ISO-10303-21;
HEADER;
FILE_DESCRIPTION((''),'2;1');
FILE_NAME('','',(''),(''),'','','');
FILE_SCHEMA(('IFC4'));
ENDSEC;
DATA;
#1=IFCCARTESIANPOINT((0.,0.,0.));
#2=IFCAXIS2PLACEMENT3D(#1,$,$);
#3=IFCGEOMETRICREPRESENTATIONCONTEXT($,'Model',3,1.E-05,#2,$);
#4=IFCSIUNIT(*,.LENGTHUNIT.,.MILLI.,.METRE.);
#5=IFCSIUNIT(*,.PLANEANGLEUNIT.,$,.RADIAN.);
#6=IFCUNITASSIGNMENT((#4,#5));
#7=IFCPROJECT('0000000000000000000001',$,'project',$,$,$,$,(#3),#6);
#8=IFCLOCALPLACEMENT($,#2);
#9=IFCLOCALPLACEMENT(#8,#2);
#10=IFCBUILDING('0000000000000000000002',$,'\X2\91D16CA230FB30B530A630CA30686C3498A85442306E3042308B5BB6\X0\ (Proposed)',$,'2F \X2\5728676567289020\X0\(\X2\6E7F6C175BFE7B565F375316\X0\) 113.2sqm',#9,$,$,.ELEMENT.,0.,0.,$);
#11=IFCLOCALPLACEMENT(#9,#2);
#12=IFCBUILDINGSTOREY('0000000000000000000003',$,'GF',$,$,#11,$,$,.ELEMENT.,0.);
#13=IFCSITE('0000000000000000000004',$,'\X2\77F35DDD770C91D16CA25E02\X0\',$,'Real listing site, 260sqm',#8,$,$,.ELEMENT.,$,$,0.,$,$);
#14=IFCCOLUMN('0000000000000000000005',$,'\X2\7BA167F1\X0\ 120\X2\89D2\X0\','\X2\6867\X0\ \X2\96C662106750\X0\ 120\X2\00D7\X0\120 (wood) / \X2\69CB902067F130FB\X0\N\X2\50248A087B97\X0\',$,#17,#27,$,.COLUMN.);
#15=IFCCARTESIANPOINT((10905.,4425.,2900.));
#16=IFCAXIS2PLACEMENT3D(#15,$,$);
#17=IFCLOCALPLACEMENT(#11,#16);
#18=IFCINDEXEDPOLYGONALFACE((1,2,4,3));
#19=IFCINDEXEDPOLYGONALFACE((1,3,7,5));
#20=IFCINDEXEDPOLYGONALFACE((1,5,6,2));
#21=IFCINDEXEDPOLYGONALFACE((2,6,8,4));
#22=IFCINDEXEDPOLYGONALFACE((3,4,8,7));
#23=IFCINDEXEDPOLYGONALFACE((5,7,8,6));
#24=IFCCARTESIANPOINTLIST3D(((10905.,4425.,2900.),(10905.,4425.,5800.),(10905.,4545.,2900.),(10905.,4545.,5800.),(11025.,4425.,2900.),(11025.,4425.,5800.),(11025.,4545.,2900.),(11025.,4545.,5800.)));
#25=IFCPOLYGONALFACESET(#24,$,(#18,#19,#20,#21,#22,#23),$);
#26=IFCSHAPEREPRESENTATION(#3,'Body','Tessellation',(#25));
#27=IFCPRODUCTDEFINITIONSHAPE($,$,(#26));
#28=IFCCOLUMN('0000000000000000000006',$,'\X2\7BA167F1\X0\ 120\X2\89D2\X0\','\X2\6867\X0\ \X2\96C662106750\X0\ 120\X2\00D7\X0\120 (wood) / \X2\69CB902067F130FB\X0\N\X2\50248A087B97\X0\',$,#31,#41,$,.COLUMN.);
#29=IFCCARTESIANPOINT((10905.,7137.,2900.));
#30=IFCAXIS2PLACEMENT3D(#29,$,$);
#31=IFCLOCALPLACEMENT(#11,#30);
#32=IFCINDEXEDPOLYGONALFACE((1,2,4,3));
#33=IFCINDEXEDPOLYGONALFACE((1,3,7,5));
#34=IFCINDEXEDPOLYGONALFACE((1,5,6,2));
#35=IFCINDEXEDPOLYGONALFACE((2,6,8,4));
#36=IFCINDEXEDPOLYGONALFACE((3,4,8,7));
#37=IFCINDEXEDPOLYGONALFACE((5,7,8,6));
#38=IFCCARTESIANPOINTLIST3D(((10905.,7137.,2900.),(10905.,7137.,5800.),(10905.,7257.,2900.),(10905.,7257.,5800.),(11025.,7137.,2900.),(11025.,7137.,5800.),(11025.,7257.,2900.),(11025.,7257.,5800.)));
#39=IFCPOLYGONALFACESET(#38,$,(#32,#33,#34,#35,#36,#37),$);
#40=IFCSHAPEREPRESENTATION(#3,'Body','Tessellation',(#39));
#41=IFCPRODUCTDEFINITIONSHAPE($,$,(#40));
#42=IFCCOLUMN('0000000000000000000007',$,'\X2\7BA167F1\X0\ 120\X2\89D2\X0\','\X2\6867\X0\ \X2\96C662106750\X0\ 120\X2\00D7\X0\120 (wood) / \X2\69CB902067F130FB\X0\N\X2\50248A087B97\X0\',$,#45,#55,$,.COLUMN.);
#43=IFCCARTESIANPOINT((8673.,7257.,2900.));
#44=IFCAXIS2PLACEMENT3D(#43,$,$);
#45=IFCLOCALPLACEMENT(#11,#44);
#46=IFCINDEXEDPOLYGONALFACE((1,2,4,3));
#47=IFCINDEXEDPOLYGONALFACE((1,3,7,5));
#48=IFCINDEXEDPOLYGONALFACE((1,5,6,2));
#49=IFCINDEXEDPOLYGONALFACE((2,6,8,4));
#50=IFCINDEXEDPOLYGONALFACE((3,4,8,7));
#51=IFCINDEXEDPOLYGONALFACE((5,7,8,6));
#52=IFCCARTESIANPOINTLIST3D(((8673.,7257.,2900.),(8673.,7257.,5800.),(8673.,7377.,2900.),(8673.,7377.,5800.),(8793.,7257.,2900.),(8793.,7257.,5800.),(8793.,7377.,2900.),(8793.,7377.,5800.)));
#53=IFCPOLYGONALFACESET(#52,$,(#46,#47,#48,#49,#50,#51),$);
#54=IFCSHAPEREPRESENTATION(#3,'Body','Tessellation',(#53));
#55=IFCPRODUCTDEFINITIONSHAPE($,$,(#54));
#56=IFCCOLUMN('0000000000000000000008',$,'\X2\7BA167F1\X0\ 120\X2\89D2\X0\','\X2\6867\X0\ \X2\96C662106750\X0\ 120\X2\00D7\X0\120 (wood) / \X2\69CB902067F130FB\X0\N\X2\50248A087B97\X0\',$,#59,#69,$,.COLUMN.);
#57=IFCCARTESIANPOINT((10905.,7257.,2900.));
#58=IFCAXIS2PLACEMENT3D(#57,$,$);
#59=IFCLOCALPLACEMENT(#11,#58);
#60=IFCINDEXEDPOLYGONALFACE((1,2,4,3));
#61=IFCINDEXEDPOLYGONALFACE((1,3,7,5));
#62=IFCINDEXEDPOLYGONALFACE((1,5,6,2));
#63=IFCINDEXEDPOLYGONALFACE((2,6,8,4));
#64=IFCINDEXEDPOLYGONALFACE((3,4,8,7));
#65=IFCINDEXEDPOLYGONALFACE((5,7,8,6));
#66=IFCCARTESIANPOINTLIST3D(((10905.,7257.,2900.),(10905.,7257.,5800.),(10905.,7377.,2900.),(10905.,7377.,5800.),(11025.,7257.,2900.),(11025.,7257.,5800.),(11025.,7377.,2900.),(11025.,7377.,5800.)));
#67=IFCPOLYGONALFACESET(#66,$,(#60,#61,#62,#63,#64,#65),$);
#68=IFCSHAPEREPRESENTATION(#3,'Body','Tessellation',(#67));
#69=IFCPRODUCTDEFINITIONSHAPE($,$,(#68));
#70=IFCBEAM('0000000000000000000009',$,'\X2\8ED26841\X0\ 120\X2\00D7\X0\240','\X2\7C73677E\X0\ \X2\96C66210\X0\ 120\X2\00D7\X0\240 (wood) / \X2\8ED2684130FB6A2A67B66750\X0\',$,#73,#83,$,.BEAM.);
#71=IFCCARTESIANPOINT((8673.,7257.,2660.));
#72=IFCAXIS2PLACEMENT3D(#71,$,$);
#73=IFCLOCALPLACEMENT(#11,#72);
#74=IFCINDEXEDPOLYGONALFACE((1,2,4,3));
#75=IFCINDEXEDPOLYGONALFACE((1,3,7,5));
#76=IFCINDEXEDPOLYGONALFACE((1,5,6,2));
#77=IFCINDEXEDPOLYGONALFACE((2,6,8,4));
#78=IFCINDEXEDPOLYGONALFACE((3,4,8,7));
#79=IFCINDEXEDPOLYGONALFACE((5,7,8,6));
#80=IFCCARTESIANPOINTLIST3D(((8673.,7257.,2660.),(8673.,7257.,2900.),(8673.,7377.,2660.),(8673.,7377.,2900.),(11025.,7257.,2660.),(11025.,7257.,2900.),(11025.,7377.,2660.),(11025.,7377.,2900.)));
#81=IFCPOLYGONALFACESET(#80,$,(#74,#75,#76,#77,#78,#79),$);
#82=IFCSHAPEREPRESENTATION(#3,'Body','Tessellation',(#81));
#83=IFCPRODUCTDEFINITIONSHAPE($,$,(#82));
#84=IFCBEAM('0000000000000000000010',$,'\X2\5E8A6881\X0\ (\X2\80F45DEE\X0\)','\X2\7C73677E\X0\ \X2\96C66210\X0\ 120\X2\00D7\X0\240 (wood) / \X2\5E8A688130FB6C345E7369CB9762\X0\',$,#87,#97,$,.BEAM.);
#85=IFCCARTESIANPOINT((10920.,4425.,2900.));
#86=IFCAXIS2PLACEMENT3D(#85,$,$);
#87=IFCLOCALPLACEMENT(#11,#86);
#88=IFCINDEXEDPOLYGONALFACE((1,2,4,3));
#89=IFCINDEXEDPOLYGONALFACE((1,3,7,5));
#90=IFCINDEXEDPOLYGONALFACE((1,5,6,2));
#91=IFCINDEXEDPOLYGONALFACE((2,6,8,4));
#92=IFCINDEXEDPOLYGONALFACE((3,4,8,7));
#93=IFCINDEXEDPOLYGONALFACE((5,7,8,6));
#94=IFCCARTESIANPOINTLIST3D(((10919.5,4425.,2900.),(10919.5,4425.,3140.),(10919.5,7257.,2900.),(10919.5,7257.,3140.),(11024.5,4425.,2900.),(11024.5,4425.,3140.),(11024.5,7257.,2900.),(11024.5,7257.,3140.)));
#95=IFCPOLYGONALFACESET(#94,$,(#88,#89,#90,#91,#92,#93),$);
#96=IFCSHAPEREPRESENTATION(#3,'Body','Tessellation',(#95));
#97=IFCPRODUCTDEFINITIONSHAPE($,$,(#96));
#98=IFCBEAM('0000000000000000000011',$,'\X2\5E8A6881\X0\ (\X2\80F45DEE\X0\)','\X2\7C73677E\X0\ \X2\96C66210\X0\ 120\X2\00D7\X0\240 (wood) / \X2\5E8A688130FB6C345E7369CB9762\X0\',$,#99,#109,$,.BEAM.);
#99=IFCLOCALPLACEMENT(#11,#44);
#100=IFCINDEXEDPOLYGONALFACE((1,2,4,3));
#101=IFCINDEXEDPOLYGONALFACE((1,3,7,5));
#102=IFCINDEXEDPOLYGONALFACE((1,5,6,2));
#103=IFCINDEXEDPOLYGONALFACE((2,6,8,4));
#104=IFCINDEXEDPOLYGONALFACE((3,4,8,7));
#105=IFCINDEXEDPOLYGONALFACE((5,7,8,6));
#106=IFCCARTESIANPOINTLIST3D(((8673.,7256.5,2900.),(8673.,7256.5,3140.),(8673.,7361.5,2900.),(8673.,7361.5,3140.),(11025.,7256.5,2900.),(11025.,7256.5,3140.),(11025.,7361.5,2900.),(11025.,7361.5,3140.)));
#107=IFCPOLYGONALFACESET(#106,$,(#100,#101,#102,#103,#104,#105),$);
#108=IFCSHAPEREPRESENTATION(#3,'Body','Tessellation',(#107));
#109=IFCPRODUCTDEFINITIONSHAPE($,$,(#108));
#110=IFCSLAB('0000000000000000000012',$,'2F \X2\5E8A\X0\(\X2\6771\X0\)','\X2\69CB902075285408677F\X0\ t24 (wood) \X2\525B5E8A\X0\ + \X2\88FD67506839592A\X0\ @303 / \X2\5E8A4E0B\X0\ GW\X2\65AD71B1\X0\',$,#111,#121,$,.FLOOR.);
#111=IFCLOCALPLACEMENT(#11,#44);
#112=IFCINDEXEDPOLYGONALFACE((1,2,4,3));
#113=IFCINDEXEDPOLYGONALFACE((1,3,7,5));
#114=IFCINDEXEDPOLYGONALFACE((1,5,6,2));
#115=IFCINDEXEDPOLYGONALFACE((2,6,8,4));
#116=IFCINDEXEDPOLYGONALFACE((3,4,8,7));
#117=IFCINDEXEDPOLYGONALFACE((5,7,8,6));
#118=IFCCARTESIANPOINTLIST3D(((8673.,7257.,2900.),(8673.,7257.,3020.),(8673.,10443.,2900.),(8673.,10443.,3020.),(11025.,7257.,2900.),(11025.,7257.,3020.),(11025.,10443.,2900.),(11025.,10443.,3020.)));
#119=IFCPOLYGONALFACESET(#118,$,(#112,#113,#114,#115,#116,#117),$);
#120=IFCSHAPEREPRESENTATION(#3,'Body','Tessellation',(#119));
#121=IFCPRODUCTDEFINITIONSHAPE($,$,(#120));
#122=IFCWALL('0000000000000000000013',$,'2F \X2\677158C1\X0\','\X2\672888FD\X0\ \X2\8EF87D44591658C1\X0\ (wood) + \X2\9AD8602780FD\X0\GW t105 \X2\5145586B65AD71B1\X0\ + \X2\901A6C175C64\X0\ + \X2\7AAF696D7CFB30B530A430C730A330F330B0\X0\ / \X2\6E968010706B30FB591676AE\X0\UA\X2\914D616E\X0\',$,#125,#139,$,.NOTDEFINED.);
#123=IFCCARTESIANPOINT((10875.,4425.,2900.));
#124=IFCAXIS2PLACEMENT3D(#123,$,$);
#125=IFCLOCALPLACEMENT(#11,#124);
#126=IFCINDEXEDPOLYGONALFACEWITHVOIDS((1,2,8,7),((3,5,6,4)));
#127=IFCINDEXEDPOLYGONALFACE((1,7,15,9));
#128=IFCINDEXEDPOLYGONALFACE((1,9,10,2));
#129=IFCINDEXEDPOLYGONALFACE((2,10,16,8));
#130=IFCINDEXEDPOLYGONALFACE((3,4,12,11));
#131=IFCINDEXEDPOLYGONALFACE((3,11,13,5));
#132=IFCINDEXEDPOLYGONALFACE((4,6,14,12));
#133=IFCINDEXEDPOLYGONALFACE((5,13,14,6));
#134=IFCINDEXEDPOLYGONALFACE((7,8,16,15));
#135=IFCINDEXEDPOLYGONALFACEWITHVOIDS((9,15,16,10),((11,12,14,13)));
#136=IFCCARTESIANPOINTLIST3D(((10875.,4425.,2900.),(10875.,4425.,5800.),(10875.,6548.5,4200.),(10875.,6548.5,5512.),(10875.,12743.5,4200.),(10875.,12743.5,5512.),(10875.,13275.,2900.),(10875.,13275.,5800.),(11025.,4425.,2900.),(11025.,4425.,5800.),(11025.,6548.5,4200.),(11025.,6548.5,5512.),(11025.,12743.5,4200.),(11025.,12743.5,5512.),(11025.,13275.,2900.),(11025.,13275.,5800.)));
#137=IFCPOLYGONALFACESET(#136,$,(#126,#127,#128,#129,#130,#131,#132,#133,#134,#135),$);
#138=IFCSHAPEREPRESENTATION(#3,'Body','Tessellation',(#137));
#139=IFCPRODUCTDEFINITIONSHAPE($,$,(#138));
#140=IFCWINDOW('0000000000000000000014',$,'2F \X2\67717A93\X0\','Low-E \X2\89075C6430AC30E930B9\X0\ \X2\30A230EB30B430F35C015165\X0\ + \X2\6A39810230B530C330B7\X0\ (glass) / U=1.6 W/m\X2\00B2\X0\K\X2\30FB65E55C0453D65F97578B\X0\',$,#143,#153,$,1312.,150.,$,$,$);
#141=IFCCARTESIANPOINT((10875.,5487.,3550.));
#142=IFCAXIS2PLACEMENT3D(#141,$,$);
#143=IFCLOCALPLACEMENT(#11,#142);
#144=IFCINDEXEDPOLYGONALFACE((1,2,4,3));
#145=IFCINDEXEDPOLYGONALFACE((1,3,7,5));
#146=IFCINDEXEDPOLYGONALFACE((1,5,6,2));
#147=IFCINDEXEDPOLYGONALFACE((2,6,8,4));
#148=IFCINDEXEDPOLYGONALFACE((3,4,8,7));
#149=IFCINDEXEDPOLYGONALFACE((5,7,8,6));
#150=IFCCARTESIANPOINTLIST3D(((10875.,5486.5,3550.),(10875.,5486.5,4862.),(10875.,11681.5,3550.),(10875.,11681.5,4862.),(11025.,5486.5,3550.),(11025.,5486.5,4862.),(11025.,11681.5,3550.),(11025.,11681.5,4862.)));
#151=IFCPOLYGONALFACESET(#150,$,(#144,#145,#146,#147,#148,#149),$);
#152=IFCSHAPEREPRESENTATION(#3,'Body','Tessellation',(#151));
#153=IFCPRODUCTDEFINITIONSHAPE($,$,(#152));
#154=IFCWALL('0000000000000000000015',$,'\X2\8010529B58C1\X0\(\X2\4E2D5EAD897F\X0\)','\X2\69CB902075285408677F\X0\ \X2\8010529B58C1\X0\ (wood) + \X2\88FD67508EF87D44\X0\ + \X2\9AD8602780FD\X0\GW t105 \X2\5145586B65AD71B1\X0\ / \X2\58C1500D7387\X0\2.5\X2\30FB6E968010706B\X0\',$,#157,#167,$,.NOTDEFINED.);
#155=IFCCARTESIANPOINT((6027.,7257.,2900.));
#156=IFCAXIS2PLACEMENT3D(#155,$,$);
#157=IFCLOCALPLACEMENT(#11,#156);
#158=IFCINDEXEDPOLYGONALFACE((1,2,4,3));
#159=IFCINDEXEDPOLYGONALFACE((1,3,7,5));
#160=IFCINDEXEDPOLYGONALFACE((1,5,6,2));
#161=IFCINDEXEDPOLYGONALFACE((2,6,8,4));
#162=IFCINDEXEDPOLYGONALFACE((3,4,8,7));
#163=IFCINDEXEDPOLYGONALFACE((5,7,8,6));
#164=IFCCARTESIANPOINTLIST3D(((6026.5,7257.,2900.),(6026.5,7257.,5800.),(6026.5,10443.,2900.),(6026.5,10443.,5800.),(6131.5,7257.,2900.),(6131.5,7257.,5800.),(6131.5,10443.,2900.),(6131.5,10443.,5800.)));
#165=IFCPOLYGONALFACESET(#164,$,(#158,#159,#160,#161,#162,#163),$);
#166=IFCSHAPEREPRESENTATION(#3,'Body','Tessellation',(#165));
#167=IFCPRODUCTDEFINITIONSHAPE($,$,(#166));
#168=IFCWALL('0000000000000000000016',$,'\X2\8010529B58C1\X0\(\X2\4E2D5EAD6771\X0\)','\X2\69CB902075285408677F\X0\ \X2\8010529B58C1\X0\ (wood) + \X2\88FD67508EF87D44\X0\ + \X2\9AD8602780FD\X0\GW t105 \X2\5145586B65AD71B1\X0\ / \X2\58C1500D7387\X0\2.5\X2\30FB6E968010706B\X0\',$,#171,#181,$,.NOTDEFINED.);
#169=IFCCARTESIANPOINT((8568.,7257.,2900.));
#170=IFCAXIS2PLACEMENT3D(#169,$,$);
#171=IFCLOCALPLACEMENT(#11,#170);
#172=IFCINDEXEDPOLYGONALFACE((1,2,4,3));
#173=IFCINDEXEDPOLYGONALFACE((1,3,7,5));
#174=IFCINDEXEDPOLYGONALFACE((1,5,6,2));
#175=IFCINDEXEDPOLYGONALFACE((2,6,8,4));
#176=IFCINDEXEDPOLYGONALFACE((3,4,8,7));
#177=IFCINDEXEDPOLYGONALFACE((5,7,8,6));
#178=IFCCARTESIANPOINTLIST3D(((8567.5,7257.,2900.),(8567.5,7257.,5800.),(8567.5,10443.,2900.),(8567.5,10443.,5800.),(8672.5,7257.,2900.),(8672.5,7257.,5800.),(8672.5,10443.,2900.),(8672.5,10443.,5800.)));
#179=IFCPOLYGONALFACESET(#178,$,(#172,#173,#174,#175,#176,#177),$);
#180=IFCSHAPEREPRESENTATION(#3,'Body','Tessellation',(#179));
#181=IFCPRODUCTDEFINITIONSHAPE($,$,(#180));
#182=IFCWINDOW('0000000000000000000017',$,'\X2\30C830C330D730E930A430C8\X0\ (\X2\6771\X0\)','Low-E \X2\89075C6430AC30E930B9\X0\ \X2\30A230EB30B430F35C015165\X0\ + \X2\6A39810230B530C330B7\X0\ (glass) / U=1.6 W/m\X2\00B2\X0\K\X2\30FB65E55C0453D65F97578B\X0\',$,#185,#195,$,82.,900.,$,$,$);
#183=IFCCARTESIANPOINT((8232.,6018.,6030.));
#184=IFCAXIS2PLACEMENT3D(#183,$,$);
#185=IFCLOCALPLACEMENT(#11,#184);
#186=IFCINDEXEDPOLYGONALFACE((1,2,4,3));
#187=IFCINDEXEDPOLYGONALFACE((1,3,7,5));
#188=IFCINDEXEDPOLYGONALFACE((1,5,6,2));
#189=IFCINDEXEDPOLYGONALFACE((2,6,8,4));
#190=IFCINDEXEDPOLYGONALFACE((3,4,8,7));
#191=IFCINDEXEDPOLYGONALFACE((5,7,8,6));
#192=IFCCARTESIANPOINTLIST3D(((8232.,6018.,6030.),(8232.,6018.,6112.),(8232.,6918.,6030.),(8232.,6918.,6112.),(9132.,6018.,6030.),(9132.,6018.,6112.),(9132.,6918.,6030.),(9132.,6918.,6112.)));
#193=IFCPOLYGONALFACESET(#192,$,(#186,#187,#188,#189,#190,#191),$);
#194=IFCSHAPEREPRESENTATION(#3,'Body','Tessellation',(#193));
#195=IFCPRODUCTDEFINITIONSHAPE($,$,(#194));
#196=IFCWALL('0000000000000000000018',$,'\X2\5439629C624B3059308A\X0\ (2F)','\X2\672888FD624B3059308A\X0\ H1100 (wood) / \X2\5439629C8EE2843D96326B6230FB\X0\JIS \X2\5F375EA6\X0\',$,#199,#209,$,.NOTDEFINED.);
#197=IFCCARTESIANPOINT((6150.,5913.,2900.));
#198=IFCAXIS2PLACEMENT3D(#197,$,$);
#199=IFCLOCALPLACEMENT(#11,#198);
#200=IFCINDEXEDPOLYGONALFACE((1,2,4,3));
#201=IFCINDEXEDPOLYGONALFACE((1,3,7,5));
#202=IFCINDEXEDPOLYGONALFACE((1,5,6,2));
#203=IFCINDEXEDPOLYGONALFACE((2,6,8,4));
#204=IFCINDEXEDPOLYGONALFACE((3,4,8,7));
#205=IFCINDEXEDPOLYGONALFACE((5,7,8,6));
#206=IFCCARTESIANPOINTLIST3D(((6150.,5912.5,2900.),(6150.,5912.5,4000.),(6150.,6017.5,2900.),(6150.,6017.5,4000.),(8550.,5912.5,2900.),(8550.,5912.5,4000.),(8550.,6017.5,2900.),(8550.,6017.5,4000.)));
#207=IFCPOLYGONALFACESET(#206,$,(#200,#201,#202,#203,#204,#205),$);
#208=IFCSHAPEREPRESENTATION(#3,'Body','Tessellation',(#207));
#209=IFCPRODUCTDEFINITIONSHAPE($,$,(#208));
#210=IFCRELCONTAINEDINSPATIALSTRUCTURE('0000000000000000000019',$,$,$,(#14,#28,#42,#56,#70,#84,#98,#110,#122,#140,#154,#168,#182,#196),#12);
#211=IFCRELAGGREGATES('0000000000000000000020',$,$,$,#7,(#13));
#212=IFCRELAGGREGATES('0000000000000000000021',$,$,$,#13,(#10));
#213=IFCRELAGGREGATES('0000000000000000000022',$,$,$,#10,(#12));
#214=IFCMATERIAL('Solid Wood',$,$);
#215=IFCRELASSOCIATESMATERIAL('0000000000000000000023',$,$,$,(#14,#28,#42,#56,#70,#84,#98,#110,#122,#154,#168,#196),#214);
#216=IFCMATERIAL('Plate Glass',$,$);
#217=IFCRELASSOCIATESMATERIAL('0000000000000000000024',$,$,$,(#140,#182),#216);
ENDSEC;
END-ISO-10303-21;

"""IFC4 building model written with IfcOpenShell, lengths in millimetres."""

from ifc_helpers import new_model, si_unit, frame, frame_2d, origin, place, context, project, spatial, rectangle, extrude, material, element, fill, save


model = new_model("IFC4")

# Units and contexts
model_context = context("Model", 3, precision=1e-05, world=origin())
ifc_project = project(units=[si_unit("LENGTHUNIT", "METRE", prefix="MILLI"), si_unit("PLANEANGLEUNIT", "RADIAN")], contexts=[model_context])

# Site, building, storey
site_placement = place(None, origin())
site = spatial("IfcSite", under=ifc_project, at=site_placement, Name="石川県金沢市", ObjectType="Real listing site, 260sqm", CompositionType="ELEMENT", RefElevation=0.0)
building_placement = place(site_placement, origin())
building = spatial("IfcBuilding", under=site, at=building_placement, Name="金沢・サウナと水風呂のある家 (Proposed)", ObjectType="2F 在来木造(湿気対策強化) 113.2sqm", CompositionType="ELEMENT", ElevationOfRefHeight=0.0, ElevationOfTerrain=0.0)
storey_placement = place(building_placement, origin())
storey = spatial("IfcBuildingStorey", under=building, at=storey_placement, Name="GF", CompositionType="ELEMENT", Elevation=0.0)

# Columns
ifc_material_1 = material(Name="Solid Wood")
column_1_placement = place(storey_placement, frame((10905.0, 4425.0, 2900.0)))
element("IfcColumn", 1, at=column_1_placement, inside=storey, material=ifc_material_1, Name="管柱 120角", Description="桧 集成材 120×120 (wood) / 構造柱・N値計算", PredefinedType="COLUMN", context=model_context, shape_type="SweptSolid", body=[
    extrude(rectangle(XDim=120.0, YDim=120.0, at=frame_2d((60.0, 60.0))), frame((10905.0, 4425.0, 2900.0)), (0.0, 0.0, 1.0), 2900.0),
])
column_2_placement = place(storey_placement, frame((10905.0, 7137.0, 2900.0)))
element("IfcColumn", 2, at=column_2_placement, inside=storey, material=ifc_material_1, Name="管柱 120角", Description="桧 集成材 120×120 (wood) / 構造柱・N値計算", PredefinedType="COLUMN", context=model_context, shape_type="SweptSolid", body=[
    extrude(rectangle(XDim=120.0, YDim=120.0, at=frame_2d((60.0, 60.0))), frame((10905.0, 7137.0, 2900.0)), (0.0, 0.0, 1.0), 2900.0),
])
column_3_placement = place(storey_placement, frame((8673.0, 7257.0, 2900.0)))
element("IfcColumn", 3, at=column_3_placement, inside=storey, material=ifc_material_1, Name="管柱 120角", Description="桧 集成材 120×120 (wood) / 構造柱・N値計算", PredefinedType="COLUMN", context=model_context, shape_type="SweptSolid", body=[
    extrude(rectangle(XDim=120.0, YDim=120.0, at=frame_2d((60.0, 60.0))), frame((8673.0, 7257.0, 2900.0)), (0.0, 0.0, 1.0), 2900.0),
])
column_4_placement = place(storey_placement, frame((10905.0, 7257.0, 2900.0)))
element("IfcColumn", 4, at=column_4_placement, inside=storey, material=ifc_material_1, Name="管柱 120角", Description="桧 集成材 120×120 (wood) / 構造柱・N値計算", PredefinedType="COLUMN", context=model_context, shape_type="SweptSolid", body=[
    extrude(rectangle(XDim=120.0, YDim=120.0, at=frame_2d((60.0, 60.0))), frame((10905.0, 7257.0, 2900.0)), (0.0, 0.0, 1.0), 2900.0),
])

# Beams
beam_1_placement = place(storey_placement, frame((8673.0, 7257.0, 2660.0)))
element("IfcBeam", 5, at=beam_1_placement, inside=storey, material=ifc_material_1, Name="軒桁 120×240", Description="米松 集成 120×240 (wood) / 軒桁・横架材", PredefinedType="BEAM", context=model_context, shape_type="SweptSolid", body=[
    extrude(rectangle(XDim=2352.0, YDim=120.0, at=frame_2d((1176.0, 60.0))), frame((8673.0, 7257.0, 2660.0)), (0.0, 0.0, 1.0), 240.0),
])
beam_2_placement = place(storey_placement, frame((10920.0, 4425.0, 2900.0)))
element("IfcBeam", 6, at=beam_2_placement, inside=storey, material=ifc_material_1, Name="床梁 (胴差)", Description="米松 集成 120×240 (wood) / 床梁・水平構面", PredefinedType="BEAM", context=model_context, shape_type="SweptSolid", body=[
    extrude(rectangle(XDim=105.0, YDim=2832.0, at=frame_2d((52.0, 1416.0))), frame((10920.0, 4425.0, 2900.0)), (0.0, 0.0, 1.0), 240.0),
])
beam_3_placement = place(storey_placement, frame((8673.0, 7257.0, 2900.0)))
element("IfcBeam", 7, at=beam_3_placement, inside=storey, material=ifc_material_1, Name="床梁 (胴差)", Description="米松 集成 120×240 (wood) / 床梁・水平構面", PredefinedType="BEAM", context=model_context, shape_type="SweptSolid", body=[
    extrude(rectangle(XDim=2352.0, YDim=105.0, at=frame_2d((1176.0, 52.0))), frame((8673.0, 7257.0, 2900.0)), (0.0, 0.0, 1.0), 240.0),
])

# Slab
slab_placement = place(storey_placement, frame((8673.0, 7257.0, 2900.0)))
element("IfcSlab", 8, at=slab_placement, inside=storey, material=ifc_material_1, Name="2F 床(東)", Description="構造用合板 t24 (wood) 剛床 + 製材根太 @303 / 床下 GW断熱", PredefinedType="FLOOR", context=model_context, shape_type="SweptSolid", body=[
    extrude(rectangle(XDim=2352.0, YDim=3186.0, at=frame_2d((1176.0, 1593.0))), frame((8673.0, 7257.0, 2900.0)), (0.0, 0.0, 1.0), 120.0),
])

# Wall, opening, window
wall_1_placement = place(storey_placement, frame((10875.0, 4425.0, 2900.0)))
wall_1 = element("IfcWall", 9, at=wall_1_placement, inside=storey, material=ifc_material_1, Name="2F 東壁", Description="木製 軸組外壁 (wood) + 高性能GW t105 充填断熱 + 通気層 + 窯業系サイディング / 準耐火・外皮UA配慮", PredefinedType="NOTDEFINED", context=model_context, shape_type="SweptSolid", body=[
    extrude(rectangle(XDim=150.0, YDim=8850.0, at=frame_2d((75.0, 4425.0))), frame((10875.0, 4425.0, 2900.0)), (0.0, 0.0, 1.0), 2900.0),
])
opening_placement = place(storey_placement, frame((10875.0, 5487.0, 3550.0)))
opening = element("IfcOpeningElement", 10, at=opening_placement, cuts=wall_1, PredefinedType="NOTDEFINED", context=model_context, shape_type="SweptSolid", body=[
    extrude(rectangle(XDim=150.0, YDim=6195.0, at=frame_2d((75.0, 3097.0))), frame((10875.0, 5487.0, 3550.0)), (0.0, 0.0, 1.0), 1312.0),
])
ifc_material_2 = material(Name="Plate Glass")
window_1_placement = place(storey_placement, frame((10875.0, 5487.0, 3550.0)))
window_1 = element("IfcWindow", 11, at=window_1_placement, inside=storey, material=ifc_material_2, Name="2F 東窓", Description="Low-E 複層ガラス アルゴン封入 + 樹脂サッシ (glass) / U=1.6 W/m²K・日射取得型", OverallHeight=1312.0, OverallWidth=150.0, context=model_context, shape_type="SweptSolid", body=[
    extrude(rectangle(XDim=150.0, YDim=6195.0, at=frame_2d((75.0, 3097.0))), frame((10875.0, 5487.0, 3550.0)), (0.0, 0.0, 1.0), 1312.0),
])
fill(opening, window_1)

# Walls
wall_2_placement = place(storey_placement, frame((6027.0, 7257.0, 2900.0)))
element("IfcWall", 12, at=wall_2_placement, inside=storey, material=ifc_material_1, Name="耐力壁(中庭西)", Description="構造用合板 耐力壁 (wood) + 製材軸組 + 高性能GW t105 充填断熱 / 壁倍率2.5・準耐火", PredefinedType="NOTDEFINED", context=model_context, shape_type="SweptSolid", body=[
    extrude(rectangle(XDim=105.0, YDim=3186.0, at=frame_2d((52.0, 1593.0))), frame((6027.0, 7257.0, 2900.0)), (0.0, 0.0, 1.0), 2900.0),
])
wall_3_placement = place(storey_placement, frame((8568.0, 7257.0, 2900.0)))
element("IfcWall", 13, at=wall_3_placement, inside=storey, material=ifc_material_1, Name="耐力壁(中庭東)", Description="構造用合板 耐力壁 (wood) + 製材軸組 + 高性能GW t105 充填断熱 / 壁倍率2.5・準耐火", PredefinedType="NOTDEFINED", context=model_context, shape_type="SweptSolid", body=[
    extrude(rectangle(XDim=105.0, YDim=3186.0, at=frame_2d((52.0, 1593.0))), frame((8568.0, 7257.0, 2900.0)), (0.0, 0.0, 1.0), 2900.0),
])

# Window
window_2_placement = place(storey_placement, frame((8232.0, 6018.0, 6030.0)))
element("IfcWindow", 14, at=window_2_placement, inside=storey, material=ifc_material_2, Name="トップライト (東)", Description="Low-E 複層ガラス アルゴン封入 + 樹脂サッシ (glass) / U=1.6 W/m²K・日射取得型", OverallHeight=82.0, OverallWidth=900.0, context=model_context, shape_type="SweptSolid", body=[
    extrude(rectangle(XDim=900.0, YDim=900.0, at=frame_2d((450.0, 450.0))), frame((8232.0, 6018.0, 6030.0)), (0.0, 0.0, 1.0), 82.0),
])

# Wall
wall_4_placement = place(storey_placement, frame((6150.0, 5913.0, 2900.0)))
element("IfcWall", 15, at=wall_4_placement, inside=storey, material=ifc_material_1, Name="吹抜手すり (2F)", Description="木製手すり H1100 (wood) / 吹抜転落防止・JIS 強度", PredefinedType="NOTDEFINED", context=model_context, shape_type="SweptSolid", body=[
    extrude(rectangle(XDim=2400.0, YDim=105.0, at=frame_2d((1200.0, 52.0))), frame((6150.0, 5913.0, 2900.0)), (0.0, 0.0, 1.0), 1100.0),
])

save(model, "model.ifc")
